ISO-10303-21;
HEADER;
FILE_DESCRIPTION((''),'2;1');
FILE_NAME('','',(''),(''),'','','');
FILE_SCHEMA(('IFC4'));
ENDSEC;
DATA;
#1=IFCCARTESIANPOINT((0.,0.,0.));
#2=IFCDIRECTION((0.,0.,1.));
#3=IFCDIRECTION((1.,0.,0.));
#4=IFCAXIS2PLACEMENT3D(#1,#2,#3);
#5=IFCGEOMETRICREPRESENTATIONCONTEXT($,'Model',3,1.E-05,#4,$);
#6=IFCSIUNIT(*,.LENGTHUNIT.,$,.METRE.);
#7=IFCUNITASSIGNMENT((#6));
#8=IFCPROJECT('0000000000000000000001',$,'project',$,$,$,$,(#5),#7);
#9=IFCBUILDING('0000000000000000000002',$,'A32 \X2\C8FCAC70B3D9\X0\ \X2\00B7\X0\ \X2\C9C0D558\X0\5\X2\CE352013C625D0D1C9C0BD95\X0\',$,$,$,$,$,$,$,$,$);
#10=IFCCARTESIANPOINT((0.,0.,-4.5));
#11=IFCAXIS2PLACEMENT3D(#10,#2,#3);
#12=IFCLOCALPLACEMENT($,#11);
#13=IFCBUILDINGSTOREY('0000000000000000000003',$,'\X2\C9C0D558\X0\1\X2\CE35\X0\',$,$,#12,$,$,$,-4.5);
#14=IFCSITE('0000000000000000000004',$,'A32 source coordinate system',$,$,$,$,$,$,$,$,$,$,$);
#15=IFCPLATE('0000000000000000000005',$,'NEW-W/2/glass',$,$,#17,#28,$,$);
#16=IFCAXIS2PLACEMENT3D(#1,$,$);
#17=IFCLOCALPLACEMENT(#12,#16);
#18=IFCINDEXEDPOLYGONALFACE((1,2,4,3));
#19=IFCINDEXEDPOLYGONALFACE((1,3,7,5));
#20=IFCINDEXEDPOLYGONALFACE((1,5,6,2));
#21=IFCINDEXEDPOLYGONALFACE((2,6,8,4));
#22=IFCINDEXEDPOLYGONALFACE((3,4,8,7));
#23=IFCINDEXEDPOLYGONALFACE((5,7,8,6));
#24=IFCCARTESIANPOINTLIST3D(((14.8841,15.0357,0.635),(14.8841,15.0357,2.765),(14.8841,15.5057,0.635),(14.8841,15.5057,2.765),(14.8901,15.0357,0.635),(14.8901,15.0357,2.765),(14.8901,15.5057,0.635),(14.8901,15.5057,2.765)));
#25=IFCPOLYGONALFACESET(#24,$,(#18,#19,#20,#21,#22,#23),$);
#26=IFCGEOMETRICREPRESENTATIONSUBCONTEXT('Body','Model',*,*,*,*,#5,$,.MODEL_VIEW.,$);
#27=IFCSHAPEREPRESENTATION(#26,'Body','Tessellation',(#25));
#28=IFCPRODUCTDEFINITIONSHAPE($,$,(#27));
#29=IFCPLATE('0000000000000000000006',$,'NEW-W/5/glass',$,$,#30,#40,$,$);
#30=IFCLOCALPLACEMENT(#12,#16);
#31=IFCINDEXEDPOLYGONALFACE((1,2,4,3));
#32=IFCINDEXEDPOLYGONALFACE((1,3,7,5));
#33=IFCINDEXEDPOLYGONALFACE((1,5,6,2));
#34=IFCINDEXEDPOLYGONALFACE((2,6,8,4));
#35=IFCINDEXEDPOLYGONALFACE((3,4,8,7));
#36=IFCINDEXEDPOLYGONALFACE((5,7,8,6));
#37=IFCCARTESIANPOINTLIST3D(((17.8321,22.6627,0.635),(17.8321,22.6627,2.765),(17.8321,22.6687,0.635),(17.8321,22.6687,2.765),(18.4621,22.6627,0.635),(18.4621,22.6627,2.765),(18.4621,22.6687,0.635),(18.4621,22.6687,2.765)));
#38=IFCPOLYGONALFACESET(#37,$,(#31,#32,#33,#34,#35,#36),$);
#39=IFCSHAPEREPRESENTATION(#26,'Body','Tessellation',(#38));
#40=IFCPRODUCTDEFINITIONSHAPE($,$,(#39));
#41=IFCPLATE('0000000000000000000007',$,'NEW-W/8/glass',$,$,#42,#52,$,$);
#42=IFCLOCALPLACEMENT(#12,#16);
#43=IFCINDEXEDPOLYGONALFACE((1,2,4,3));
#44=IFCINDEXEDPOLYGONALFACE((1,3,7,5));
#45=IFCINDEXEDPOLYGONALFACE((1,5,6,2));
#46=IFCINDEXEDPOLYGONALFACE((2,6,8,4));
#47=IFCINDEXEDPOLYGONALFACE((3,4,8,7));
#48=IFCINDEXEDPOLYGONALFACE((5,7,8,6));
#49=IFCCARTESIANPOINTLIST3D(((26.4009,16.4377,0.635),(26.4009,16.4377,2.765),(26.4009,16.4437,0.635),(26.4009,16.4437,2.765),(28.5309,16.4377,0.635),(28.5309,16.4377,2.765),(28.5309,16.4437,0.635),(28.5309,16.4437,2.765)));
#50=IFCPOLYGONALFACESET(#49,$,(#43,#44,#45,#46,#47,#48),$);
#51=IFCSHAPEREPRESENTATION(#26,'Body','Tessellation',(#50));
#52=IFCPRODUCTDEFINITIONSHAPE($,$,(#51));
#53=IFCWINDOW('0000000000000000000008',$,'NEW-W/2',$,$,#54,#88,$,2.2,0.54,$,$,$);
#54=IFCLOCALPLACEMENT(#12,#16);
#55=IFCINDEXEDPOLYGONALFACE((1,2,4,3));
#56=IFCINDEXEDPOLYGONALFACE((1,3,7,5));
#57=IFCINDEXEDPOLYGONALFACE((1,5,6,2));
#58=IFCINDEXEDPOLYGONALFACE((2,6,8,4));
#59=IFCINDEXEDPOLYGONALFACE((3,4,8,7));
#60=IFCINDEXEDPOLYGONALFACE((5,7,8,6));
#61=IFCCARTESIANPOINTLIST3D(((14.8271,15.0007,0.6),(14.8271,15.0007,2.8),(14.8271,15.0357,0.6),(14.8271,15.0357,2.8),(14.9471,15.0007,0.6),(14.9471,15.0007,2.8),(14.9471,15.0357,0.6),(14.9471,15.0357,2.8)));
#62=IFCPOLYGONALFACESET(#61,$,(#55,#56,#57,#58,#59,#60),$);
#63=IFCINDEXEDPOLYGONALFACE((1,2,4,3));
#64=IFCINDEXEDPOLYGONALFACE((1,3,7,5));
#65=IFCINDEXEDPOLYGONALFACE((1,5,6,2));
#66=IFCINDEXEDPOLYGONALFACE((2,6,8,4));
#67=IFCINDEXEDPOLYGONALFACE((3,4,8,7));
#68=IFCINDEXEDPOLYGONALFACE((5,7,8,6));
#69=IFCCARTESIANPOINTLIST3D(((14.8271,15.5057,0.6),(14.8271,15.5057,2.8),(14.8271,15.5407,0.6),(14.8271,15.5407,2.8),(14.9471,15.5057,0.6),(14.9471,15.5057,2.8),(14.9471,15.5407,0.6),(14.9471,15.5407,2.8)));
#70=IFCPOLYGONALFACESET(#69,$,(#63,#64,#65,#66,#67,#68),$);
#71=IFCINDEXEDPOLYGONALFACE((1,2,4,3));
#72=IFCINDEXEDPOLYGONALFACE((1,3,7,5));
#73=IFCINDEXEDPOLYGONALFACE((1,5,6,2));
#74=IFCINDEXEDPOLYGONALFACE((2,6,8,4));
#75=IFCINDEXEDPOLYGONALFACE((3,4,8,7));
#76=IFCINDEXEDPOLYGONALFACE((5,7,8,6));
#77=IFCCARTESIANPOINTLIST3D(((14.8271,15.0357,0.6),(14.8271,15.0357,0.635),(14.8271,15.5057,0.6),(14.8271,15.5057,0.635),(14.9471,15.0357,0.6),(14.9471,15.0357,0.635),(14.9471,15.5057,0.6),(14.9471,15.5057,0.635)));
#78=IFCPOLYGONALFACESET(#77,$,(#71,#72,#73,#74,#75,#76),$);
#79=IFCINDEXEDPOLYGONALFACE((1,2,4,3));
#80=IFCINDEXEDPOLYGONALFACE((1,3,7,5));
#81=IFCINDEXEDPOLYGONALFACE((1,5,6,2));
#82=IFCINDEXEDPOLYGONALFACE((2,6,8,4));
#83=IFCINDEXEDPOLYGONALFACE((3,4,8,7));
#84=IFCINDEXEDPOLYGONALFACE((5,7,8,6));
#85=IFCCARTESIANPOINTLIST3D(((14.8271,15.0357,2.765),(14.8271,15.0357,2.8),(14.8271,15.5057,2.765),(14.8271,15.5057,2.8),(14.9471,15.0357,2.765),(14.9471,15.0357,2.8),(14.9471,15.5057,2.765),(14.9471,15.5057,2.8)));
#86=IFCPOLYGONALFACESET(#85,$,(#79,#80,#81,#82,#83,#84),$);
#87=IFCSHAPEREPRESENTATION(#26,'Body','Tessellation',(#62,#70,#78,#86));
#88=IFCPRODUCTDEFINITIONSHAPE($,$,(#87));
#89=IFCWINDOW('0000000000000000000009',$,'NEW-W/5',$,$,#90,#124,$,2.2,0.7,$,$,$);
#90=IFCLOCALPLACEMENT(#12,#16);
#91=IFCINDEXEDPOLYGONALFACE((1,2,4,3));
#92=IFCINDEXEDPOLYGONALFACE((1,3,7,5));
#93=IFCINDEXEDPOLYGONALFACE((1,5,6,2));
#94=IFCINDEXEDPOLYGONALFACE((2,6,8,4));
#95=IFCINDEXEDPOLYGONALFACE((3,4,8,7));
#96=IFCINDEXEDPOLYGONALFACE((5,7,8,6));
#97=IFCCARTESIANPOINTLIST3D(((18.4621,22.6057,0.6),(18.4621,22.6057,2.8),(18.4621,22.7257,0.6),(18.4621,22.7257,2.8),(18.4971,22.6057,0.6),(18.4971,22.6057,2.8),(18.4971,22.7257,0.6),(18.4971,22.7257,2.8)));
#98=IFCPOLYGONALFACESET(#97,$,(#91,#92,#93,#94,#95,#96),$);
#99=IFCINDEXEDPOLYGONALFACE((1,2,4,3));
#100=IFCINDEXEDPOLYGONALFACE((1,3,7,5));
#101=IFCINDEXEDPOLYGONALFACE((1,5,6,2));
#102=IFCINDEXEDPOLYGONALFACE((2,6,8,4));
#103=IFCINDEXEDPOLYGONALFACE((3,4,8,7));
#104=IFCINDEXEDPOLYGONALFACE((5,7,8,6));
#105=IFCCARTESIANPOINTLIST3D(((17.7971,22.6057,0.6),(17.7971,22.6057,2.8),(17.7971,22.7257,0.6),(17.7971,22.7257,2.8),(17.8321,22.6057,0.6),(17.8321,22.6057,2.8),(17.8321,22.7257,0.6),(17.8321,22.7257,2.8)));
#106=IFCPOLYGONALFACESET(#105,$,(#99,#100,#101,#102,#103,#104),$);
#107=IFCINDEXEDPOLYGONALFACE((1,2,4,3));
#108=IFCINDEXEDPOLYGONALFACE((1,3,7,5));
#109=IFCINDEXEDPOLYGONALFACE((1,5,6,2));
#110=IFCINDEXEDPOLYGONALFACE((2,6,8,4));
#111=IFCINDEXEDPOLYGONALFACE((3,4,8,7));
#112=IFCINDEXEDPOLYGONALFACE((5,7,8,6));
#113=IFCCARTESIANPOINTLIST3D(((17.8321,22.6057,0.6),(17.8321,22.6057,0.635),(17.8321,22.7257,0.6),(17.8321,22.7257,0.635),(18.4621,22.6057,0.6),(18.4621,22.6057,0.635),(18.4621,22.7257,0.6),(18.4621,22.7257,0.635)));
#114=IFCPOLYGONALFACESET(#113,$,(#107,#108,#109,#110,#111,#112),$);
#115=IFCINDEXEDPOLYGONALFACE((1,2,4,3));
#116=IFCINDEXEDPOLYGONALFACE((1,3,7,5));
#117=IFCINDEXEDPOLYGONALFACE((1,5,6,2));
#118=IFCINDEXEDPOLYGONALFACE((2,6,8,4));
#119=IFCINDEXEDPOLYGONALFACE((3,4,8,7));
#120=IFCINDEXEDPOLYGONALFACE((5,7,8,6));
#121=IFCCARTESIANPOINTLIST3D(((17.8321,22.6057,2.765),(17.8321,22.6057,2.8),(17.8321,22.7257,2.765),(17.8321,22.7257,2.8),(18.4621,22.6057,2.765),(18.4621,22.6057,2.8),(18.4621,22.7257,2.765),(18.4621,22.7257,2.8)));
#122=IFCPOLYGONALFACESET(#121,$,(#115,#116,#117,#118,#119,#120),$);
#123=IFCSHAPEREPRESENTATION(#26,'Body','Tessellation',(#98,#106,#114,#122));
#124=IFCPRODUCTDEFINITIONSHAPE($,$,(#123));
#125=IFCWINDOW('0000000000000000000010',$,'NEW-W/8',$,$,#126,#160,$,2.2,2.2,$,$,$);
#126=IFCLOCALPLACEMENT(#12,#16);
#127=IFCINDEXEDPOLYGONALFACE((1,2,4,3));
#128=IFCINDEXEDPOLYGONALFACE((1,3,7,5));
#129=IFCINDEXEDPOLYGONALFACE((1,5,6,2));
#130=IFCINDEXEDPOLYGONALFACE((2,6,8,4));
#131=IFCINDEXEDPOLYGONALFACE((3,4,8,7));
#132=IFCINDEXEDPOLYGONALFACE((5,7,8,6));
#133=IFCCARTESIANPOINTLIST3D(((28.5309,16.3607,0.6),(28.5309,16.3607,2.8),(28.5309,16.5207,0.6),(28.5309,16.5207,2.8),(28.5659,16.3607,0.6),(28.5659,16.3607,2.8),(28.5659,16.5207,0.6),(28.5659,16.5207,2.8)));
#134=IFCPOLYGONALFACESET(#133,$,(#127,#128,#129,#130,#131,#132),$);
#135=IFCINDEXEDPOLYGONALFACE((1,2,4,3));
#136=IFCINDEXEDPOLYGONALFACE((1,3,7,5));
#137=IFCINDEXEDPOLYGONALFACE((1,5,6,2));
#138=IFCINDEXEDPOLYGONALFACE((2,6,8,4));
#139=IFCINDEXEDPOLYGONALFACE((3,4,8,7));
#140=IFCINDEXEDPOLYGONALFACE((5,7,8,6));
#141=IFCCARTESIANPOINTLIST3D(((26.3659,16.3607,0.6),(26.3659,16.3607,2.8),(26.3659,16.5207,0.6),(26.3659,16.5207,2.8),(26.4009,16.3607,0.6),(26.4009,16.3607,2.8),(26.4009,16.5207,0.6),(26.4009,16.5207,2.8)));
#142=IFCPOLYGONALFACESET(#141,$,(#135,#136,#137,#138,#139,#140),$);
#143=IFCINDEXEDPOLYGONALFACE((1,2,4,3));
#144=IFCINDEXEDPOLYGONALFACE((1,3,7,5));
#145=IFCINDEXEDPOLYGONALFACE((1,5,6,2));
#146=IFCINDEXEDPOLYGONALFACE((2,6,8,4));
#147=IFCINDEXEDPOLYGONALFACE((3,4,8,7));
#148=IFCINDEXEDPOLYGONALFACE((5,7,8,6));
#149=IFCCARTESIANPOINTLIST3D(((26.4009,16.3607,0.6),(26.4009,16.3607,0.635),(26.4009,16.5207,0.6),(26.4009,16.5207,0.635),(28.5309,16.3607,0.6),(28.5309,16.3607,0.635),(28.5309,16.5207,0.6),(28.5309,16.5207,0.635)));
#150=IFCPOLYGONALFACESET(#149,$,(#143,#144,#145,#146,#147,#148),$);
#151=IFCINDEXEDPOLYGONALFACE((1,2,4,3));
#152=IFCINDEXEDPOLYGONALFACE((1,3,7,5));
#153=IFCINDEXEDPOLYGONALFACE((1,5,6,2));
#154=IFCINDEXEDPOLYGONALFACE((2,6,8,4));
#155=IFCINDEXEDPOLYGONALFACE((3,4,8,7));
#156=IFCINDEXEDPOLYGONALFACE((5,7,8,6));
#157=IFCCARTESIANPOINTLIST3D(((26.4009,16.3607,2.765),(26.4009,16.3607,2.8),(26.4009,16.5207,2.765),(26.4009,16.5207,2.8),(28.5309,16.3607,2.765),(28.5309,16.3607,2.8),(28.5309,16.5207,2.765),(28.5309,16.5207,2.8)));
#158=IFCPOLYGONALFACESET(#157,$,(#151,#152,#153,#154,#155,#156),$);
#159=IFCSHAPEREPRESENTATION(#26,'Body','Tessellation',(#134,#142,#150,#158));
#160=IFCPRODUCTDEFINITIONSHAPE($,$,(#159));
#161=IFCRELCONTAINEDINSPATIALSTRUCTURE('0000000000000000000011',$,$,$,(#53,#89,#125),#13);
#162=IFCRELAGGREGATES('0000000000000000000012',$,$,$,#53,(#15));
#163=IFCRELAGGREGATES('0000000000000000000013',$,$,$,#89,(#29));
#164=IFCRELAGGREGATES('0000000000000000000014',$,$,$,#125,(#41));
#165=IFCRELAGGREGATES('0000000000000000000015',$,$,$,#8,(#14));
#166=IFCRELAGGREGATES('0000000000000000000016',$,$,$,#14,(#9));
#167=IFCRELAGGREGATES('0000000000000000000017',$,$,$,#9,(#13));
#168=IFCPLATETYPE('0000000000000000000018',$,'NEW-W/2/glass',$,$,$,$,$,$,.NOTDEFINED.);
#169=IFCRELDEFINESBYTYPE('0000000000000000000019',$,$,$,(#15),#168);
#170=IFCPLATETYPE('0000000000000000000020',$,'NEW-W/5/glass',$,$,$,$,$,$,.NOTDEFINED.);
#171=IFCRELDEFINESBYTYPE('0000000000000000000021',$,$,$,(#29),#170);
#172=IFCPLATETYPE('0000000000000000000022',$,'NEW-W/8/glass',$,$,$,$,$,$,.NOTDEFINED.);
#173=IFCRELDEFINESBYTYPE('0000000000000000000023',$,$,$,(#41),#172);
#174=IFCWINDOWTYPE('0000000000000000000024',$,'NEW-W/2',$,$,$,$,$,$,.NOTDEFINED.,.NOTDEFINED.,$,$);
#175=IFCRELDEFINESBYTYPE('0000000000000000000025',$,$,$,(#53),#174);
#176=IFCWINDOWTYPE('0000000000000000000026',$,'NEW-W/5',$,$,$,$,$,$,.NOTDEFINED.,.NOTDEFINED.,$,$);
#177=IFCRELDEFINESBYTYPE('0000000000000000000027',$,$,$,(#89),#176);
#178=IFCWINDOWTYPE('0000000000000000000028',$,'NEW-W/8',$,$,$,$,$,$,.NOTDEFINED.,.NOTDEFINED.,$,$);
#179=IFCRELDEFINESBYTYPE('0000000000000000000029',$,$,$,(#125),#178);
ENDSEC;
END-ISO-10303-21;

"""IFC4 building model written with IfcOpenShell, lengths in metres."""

from ifc_helpers import new_model, si_unit, frame, origin, origin_with_axes, place, context, subcontext, project, spatial, polyline, outline, extrude, source, transform, mapped, type_object, type_shapes, element, aggregate, save


model = new_model("IFC4")

# Units and contexts
model_context = context("Model", 3, precision=1e-05, world=origin_with_axes())
body_context = subcontext(model_context, "Body", "Model", "MODEL_VIEW")
ifc_project = project(units=[si_unit("LENGTHUNIT", "METRE")], contexts=[model_context])

# Plates
plate_type_1 = type_object("IfcPlateType", Name="NEW-W/2/glass", PredefinedType="NOTDEFINED")
shared_shape_1 = source(origin(), body_context, "Body", "SweptSolid", [
    extrude(outline(polyline([(14.8901, 15.0357), (14.8841, 15.0357), (14.8841, 15.5057), (14.8901, 15.5057), (14.8901, 15.0357)])), frame((0.0, 0.0, 0.635)), (0.0, 0.0, 1.0), 2.13),
])
type_shapes(plate_type_1, [shared_shape_1])
storey_placement = place(None, frame((0.0, 0.0, -4.5), z_axis=(0.0, 0.0, 1.0), x_axis=(1.0, 0.0, 0.0)))
window_1_placement = place(storey_placement, origin_with_axes())
plate_1_placement = place(window_1_placement, origin_with_axes())
plate_1 = element("IfcPlate", 1, at=plate_1_placement, type_object=plate_type_1, Name="NEW-W/2/glass", context=body_context, shape_type="MappedRepresentation", body=[
    mapped(shared_shape_1, transform((0.0, 0.0, 0.0), scale=1.0)),
])
plate_type_2 = type_object("IfcPlateType", Name="NEW-W/5/glass", PredefinedType="NOTDEFINED")
shared_shape_2 = source(origin(), body_context, "Body", "SweptSolid", [
    extrude(outline(polyline([(18.4621, 22.6627), (17.8321, 22.6627), (17.8321, 22.6687), (18.4621, 22.6687), (18.4621, 22.6627)])), frame((0.0, 0.0, 0.635)), (0.0, 0.0, 1.0), 2.13),
])
type_shapes(plate_type_2, [shared_shape_2])
window_2_placement = place(storey_placement, origin_with_axes())
plate_2_placement = place(window_2_placement, origin_with_axes())
plate_2 = element("IfcPlate", 2, at=plate_2_placement, type_object=plate_type_2, Name="NEW-W/5/glass", context=body_context, shape_type="MappedRepresentation", body=[
    mapped(shared_shape_2, transform((0.0, 0.0, 0.0), scale=1.0)),
])
plate_type_3 = type_object("IfcPlateType", Name="NEW-W/8/glass", PredefinedType="NOTDEFINED")
shared_shape_3 = source(origin(), body_context, "Body", "SweptSolid", [
    extrude(outline(polyline([(28.5309, 16.4377), (26.4009, 16.4377), (26.4009, 16.4437), (28.5309, 16.4437), (28.5309, 16.4377)])), frame((0.0, 0.0, 0.635)), (0.0, 0.0, 1.0), 2.13),
])
type_shapes(plate_type_3, [shared_shape_3])
window_3_placement = place(storey_placement, origin_with_axes())
plate_3_placement = place(window_3_placement, origin_with_axes())
plate_3 = element("IfcPlate", 3, at=plate_3_placement, type_object=plate_type_3, Name="NEW-W/8/glass", context=body_context, shape_type="MappedRepresentation", body=[
    mapped(shared_shape_3, transform((0.0, 0.0, 0.0), scale=1.0)),
])

# Site, building, storey
site = spatial("IfcSite", under=ifc_project, Name="A32 source coordinate system")
building = spatial("IfcBuilding", under=site, Name="A32 주거동 · 지하5층–옥탑지붕")
storey = spatial("IfcBuildingStorey", under=building, at=storey_placement, Name="지하1층", Elevation=-4.5)

# Windows
window_type_1 = type_object("IfcWindowType", Name="NEW-W/2", PartitioningType="NOTDEFINED", PredefinedType="NOTDEFINED")
shared_shape_4 = source(origin(), body_context, "Body", "SweptSolid", [
    extrude(outline(polyline([(14.8271, 15.0007), (14.8271, 15.0357), (14.9471, 15.0357), (14.9471, 15.0007), (14.8271, 15.0007)])), frame((0.0, 0.0, 0.6)), (0.0, 0.0, 1.0), 2.2),
    extrude(outline(polyline([(14.8271, 15.5057), (14.8271, 15.5407), (14.9471, 15.5407), (14.9471, 15.5057), (14.8271, 15.5057)])), frame((0.0, 0.0, 0.6)), (0.0, 0.0, 1.0), 2.2),
    extrude(outline(polyline([(14.9471, 15.0357), (14.9471, 15.5057), (14.8271, 15.5057), (14.8271, 15.0357), (14.9471, 15.0357)])), frame((0.0, 0.0, 0.6)), (0.0, 0.0, 1.0), 0.035),
    extrude(outline(polyline([(14.9471, 15.0357), (14.9471, 15.5057), (14.8271, 15.5057), (14.8271, 15.0357), (14.9471, 15.0357)])), frame((0.0, 0.0, 2.765)), (0.0, 0.0, 1.0), 0.035),
])
type_shapes(window_type_1, [shared_shape_4])
window_1 = element("IfcWindow", 4, at=window_1_placement, inside=storey, type_object=window_type_1, Name="NEW-W/2", OverallHeight=2.2, OverallWidth=0.54, context=body_context, shape_type="MappedRepresentation", body=[
    mapped(shared_shape_4, transform((0.0, 0.0, 0.0), scale=1.0)),
])
aggregate(window_1, [plate_1])
window_type_2 = type_object("IfcWindowType", Name="NEW-W/5", PartitioningType="NOTDEFINED", PredefinedType="NOTDEFINED")
shared_shape_5 = source(origin(), body_context, "Body", "SweptSolid", [
    extrude(outline(polyline([(18.4621, 22.6057), (18.4621, 22.7257), (18.4971, 22.7257), (18.4971, 22.6057), (18.4621, 22.6057)])), frame((0.0, 0.0, 0.6)), (0.0, 0.0, 1.0), 2.2),
    extrude(outline(polyline([(17.7971, 22.6057), (17.7971, 22.7257), (17.8321, 22.7257), (17.8321, 22.6057), (17.7971, 22.6057)])), frame((0.0, 0.0, 0.6)), (0.0, 0.0, 1.0), 2.2),
    extrude(outline(polyline([(18.4621, 22.6057), (18.4621, 22.7257), (17.8321, 22.7257), (17.8321, 22.6057), (18.4621, 22.6057)])), frame((0.0, 0.0, 0.6)), (0.0, 0.0, 1.0), 0.035),
    extrude(outline(polyline([(18.4621, 22.6057), (18.4621, 22.7257), (17.8321, 22.7257), (17.8321, 22.6057), (18.4621, 22.6057)])), frame((0.0, 0.0, 2.765)), (0.0, 0.0, 1.0), 0.035),
])
type_shapes(window_type_2, [shared_shape_5])
window_2 = element("IfcWindow", 5, at=window_2_placement, inside=storey, type_object=window_type_2, Name="NEW-W/5", OverallHeight=2.2, OverallWidth=0.7, context=body_context, shape_type="MappedRepresentation", body=[
    mapped(shared_shape_5, transform((0.0, 0.0, 0.0), scale=1.0)),
])
aggregate(window_2, [plate_2])
window_type_3 = type_object("IfcWindowType", Name="NEW-W/8", PartitioningType="NOTDEFINED", PredefinedType="NOTDEFINED")
shared_shape_6 = source(origin(), body_context, "Body", "SweptSolid", [
    extrude(outline(polyline([(28.5309, 16.3607), (28.5309, 16.5207), (28.5659, 16.5207), (28.5659, 16.3607), (28.5309, 16.3607)])), frame((0.0, 0.0, 0.6)), (0.0, 0.0, 1.0), 2.2),
    extrude(outline(polyline([(26.3659, 16.3607), (26.3659, 16.5207), (26.4009, 16.5207), (26.4009, 16.3607), (26.3659, 16.3607)])), frame((0.0, 0.0, 0.6)), (0.0, 0.0, 1.0), 2.2),
    extrude(outline(polyline([(28.5309, 16.3607), (28.5309, 16.5207), (26.4009, 16.5207), (26.4009, 16.3607), (28.5309, 16.3607)])), frame((0.0, 0.0, 0.6)), (0.0, 0.0, 1.0), 0.035),
    extrude(outline(polyline([(28.5309, 16.3607), (28.5309, 16.5207), (26.4009, 16.5207), (26.4009, 16.3607), (28.5309, 16.3607)])), frame((0.0, 0.0, 2.765)), (0.0, 0.0, 1.0), 0.035),
])
type_shapes(window_type_3, [shared_shape_6])
window_3 = element("IfcWindow", 6, at=window_3_placement, inside=storey, type_object=window_type_3, Name="NEW-W/8", OverallHeight=2.2, OverallWidth=2.2, context=body_context, shape_type="MappedRepresentation", body=[
    mapped(shared_shape_6, transform((0.0, 0.0, 0.0), scale=1.0)),
])
aggregate(window_3, [plate_3])

save(model, "model.ifc")
